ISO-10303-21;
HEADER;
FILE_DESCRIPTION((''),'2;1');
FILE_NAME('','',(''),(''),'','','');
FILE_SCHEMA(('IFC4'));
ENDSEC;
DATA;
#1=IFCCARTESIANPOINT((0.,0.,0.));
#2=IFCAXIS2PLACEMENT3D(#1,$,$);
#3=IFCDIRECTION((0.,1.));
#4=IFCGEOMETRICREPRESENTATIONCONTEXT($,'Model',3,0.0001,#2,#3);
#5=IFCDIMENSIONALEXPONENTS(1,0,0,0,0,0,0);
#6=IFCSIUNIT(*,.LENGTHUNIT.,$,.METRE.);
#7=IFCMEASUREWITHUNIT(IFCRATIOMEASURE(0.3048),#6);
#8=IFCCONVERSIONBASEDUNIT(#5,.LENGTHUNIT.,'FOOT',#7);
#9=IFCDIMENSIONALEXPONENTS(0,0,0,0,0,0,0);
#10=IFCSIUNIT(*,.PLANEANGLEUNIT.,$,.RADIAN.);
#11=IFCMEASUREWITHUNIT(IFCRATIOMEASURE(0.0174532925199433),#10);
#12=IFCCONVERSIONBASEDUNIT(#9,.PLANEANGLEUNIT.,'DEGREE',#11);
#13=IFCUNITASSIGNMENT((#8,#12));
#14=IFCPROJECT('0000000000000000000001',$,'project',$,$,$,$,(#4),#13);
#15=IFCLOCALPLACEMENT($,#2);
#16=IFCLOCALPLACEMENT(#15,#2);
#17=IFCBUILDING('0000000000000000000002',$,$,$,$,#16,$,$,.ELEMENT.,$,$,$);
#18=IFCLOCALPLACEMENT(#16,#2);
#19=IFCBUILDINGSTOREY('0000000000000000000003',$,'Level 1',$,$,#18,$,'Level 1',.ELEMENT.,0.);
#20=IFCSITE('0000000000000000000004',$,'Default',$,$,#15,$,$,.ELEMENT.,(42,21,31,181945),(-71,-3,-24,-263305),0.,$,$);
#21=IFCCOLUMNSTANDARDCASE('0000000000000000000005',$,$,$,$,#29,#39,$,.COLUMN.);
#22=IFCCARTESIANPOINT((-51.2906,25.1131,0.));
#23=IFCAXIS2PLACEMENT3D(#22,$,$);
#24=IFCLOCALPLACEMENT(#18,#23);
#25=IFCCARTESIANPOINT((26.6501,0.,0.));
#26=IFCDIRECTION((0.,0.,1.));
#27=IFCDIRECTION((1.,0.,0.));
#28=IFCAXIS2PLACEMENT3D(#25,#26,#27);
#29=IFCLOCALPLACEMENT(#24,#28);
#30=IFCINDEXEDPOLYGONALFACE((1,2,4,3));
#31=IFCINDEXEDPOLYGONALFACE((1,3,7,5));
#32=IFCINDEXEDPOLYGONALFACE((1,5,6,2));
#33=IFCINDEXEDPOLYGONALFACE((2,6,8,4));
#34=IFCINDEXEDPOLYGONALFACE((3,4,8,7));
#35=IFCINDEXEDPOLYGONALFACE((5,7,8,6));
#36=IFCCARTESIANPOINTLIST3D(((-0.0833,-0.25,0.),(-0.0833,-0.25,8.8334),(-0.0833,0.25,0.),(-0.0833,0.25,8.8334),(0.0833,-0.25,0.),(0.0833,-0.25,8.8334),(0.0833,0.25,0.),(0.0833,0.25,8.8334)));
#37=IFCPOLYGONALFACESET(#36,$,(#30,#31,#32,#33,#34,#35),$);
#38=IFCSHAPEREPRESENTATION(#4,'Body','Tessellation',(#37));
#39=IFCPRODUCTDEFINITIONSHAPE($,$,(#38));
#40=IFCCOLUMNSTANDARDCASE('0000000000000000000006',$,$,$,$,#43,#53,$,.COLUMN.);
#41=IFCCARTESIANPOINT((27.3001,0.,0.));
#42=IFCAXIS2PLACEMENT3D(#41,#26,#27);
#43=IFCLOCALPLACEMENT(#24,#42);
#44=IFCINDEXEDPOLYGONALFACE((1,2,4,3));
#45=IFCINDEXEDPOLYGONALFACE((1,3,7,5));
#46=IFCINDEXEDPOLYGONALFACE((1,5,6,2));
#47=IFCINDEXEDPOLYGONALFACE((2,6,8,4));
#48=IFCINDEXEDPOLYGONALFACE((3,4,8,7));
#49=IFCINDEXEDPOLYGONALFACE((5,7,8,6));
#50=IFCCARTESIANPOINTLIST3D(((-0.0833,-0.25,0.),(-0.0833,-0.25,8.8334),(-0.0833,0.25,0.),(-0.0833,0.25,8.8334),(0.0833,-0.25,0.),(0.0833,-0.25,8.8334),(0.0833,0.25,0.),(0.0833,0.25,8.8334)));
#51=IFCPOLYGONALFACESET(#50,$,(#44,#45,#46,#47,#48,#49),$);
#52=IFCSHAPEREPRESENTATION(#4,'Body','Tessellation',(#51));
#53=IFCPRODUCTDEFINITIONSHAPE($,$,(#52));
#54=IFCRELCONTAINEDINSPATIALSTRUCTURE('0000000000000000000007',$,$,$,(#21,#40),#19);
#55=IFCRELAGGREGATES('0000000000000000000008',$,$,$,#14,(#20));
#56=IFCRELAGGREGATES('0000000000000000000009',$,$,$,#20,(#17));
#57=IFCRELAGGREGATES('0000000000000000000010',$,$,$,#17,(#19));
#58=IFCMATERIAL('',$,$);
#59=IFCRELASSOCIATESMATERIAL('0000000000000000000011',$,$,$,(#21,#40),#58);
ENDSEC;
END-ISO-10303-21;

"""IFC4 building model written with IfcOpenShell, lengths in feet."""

from ifc_helpers import new_model, entity, si_unit, converted_unit, direction, frame, origin, place, context, project, spatial, rectangle, extrude, material, element, save


model = new_model("IFC4")

# Units and contexts
model_context = context("Model", 3, precision=0.0001, world=origin(), true_north=direction((0.0, 1.0)))
ifc_project = project(units=[converted_unit("LENGTHUNIT", "FOOT", entity("IfcRatioMeasure", 0.3048), si_unit("LENGTHUNIT", "METRE"), dimensions=[1, 0, 0, 0, 0, 0, 0]), converted_unit("PLANEANGLEUNIT", "DEGREE", entity("IfcRatioMeasure", 0.0174532925199433), si_unit("PLANEANGLEUNIT", "RADIAN"), dimensions=[0, 0, 0, 0, 0, 0, 0])], contexts=[model_context])

# Site, building, storey
site_placement = place(None, origin())
site = spatial("IfcSite", under=ifc_project, at=site_placement, Name="Default", CompositionType="ELEMENT", RefLatitude=(42, 21, 31, 181945), RefLongitude=(-71, -3, -24, -263305), RefElevation=0.0)
building_placement = place(site_placement, origin())
building = spatial("IfcBuilding", under=site, at=building_placement, CompositionType="ELEMENT")
storey_placement = place(building_placement, origin())
storey = spatial("IfcBuildingStorey", under=building, at=storey_placement, Name="Level 1", LongName="Level 1", CompositionType="ELEMENT", Elevation=0.0)

# Columns
ifc_material_1 = material(Name="")
placement_1 = place(storey_placement, frame((-51.2906, 25.1131, 0.0)))
for number, where, z_axis, x_axis in (
    (1, (26.6501, 0.0, 0.0), (0.0, 0.0, 1.0), (1.0, 0.0, 0.0)),
    (2, (27.3001, 0.0, 0.0), (0.0, 0.0, 1.0), (1.0, 0.0, 0.0)),
):
    element("IfcColumnStandardCase", number, at=place(placement_1, frame(where, z_axis=z_axis, x_axis=x_axis)), inside=storey, material=ifc_material_1, PredefinedType="COLUMN", context=model_context, shape_type="SweptSolid", body=[
        extrude(rectangle(XDim=0.1667, YDim=0.5), origin(), (0.0, 0.0, 1.0), 8.8334),
    ])

save(model, "model.ifc")
